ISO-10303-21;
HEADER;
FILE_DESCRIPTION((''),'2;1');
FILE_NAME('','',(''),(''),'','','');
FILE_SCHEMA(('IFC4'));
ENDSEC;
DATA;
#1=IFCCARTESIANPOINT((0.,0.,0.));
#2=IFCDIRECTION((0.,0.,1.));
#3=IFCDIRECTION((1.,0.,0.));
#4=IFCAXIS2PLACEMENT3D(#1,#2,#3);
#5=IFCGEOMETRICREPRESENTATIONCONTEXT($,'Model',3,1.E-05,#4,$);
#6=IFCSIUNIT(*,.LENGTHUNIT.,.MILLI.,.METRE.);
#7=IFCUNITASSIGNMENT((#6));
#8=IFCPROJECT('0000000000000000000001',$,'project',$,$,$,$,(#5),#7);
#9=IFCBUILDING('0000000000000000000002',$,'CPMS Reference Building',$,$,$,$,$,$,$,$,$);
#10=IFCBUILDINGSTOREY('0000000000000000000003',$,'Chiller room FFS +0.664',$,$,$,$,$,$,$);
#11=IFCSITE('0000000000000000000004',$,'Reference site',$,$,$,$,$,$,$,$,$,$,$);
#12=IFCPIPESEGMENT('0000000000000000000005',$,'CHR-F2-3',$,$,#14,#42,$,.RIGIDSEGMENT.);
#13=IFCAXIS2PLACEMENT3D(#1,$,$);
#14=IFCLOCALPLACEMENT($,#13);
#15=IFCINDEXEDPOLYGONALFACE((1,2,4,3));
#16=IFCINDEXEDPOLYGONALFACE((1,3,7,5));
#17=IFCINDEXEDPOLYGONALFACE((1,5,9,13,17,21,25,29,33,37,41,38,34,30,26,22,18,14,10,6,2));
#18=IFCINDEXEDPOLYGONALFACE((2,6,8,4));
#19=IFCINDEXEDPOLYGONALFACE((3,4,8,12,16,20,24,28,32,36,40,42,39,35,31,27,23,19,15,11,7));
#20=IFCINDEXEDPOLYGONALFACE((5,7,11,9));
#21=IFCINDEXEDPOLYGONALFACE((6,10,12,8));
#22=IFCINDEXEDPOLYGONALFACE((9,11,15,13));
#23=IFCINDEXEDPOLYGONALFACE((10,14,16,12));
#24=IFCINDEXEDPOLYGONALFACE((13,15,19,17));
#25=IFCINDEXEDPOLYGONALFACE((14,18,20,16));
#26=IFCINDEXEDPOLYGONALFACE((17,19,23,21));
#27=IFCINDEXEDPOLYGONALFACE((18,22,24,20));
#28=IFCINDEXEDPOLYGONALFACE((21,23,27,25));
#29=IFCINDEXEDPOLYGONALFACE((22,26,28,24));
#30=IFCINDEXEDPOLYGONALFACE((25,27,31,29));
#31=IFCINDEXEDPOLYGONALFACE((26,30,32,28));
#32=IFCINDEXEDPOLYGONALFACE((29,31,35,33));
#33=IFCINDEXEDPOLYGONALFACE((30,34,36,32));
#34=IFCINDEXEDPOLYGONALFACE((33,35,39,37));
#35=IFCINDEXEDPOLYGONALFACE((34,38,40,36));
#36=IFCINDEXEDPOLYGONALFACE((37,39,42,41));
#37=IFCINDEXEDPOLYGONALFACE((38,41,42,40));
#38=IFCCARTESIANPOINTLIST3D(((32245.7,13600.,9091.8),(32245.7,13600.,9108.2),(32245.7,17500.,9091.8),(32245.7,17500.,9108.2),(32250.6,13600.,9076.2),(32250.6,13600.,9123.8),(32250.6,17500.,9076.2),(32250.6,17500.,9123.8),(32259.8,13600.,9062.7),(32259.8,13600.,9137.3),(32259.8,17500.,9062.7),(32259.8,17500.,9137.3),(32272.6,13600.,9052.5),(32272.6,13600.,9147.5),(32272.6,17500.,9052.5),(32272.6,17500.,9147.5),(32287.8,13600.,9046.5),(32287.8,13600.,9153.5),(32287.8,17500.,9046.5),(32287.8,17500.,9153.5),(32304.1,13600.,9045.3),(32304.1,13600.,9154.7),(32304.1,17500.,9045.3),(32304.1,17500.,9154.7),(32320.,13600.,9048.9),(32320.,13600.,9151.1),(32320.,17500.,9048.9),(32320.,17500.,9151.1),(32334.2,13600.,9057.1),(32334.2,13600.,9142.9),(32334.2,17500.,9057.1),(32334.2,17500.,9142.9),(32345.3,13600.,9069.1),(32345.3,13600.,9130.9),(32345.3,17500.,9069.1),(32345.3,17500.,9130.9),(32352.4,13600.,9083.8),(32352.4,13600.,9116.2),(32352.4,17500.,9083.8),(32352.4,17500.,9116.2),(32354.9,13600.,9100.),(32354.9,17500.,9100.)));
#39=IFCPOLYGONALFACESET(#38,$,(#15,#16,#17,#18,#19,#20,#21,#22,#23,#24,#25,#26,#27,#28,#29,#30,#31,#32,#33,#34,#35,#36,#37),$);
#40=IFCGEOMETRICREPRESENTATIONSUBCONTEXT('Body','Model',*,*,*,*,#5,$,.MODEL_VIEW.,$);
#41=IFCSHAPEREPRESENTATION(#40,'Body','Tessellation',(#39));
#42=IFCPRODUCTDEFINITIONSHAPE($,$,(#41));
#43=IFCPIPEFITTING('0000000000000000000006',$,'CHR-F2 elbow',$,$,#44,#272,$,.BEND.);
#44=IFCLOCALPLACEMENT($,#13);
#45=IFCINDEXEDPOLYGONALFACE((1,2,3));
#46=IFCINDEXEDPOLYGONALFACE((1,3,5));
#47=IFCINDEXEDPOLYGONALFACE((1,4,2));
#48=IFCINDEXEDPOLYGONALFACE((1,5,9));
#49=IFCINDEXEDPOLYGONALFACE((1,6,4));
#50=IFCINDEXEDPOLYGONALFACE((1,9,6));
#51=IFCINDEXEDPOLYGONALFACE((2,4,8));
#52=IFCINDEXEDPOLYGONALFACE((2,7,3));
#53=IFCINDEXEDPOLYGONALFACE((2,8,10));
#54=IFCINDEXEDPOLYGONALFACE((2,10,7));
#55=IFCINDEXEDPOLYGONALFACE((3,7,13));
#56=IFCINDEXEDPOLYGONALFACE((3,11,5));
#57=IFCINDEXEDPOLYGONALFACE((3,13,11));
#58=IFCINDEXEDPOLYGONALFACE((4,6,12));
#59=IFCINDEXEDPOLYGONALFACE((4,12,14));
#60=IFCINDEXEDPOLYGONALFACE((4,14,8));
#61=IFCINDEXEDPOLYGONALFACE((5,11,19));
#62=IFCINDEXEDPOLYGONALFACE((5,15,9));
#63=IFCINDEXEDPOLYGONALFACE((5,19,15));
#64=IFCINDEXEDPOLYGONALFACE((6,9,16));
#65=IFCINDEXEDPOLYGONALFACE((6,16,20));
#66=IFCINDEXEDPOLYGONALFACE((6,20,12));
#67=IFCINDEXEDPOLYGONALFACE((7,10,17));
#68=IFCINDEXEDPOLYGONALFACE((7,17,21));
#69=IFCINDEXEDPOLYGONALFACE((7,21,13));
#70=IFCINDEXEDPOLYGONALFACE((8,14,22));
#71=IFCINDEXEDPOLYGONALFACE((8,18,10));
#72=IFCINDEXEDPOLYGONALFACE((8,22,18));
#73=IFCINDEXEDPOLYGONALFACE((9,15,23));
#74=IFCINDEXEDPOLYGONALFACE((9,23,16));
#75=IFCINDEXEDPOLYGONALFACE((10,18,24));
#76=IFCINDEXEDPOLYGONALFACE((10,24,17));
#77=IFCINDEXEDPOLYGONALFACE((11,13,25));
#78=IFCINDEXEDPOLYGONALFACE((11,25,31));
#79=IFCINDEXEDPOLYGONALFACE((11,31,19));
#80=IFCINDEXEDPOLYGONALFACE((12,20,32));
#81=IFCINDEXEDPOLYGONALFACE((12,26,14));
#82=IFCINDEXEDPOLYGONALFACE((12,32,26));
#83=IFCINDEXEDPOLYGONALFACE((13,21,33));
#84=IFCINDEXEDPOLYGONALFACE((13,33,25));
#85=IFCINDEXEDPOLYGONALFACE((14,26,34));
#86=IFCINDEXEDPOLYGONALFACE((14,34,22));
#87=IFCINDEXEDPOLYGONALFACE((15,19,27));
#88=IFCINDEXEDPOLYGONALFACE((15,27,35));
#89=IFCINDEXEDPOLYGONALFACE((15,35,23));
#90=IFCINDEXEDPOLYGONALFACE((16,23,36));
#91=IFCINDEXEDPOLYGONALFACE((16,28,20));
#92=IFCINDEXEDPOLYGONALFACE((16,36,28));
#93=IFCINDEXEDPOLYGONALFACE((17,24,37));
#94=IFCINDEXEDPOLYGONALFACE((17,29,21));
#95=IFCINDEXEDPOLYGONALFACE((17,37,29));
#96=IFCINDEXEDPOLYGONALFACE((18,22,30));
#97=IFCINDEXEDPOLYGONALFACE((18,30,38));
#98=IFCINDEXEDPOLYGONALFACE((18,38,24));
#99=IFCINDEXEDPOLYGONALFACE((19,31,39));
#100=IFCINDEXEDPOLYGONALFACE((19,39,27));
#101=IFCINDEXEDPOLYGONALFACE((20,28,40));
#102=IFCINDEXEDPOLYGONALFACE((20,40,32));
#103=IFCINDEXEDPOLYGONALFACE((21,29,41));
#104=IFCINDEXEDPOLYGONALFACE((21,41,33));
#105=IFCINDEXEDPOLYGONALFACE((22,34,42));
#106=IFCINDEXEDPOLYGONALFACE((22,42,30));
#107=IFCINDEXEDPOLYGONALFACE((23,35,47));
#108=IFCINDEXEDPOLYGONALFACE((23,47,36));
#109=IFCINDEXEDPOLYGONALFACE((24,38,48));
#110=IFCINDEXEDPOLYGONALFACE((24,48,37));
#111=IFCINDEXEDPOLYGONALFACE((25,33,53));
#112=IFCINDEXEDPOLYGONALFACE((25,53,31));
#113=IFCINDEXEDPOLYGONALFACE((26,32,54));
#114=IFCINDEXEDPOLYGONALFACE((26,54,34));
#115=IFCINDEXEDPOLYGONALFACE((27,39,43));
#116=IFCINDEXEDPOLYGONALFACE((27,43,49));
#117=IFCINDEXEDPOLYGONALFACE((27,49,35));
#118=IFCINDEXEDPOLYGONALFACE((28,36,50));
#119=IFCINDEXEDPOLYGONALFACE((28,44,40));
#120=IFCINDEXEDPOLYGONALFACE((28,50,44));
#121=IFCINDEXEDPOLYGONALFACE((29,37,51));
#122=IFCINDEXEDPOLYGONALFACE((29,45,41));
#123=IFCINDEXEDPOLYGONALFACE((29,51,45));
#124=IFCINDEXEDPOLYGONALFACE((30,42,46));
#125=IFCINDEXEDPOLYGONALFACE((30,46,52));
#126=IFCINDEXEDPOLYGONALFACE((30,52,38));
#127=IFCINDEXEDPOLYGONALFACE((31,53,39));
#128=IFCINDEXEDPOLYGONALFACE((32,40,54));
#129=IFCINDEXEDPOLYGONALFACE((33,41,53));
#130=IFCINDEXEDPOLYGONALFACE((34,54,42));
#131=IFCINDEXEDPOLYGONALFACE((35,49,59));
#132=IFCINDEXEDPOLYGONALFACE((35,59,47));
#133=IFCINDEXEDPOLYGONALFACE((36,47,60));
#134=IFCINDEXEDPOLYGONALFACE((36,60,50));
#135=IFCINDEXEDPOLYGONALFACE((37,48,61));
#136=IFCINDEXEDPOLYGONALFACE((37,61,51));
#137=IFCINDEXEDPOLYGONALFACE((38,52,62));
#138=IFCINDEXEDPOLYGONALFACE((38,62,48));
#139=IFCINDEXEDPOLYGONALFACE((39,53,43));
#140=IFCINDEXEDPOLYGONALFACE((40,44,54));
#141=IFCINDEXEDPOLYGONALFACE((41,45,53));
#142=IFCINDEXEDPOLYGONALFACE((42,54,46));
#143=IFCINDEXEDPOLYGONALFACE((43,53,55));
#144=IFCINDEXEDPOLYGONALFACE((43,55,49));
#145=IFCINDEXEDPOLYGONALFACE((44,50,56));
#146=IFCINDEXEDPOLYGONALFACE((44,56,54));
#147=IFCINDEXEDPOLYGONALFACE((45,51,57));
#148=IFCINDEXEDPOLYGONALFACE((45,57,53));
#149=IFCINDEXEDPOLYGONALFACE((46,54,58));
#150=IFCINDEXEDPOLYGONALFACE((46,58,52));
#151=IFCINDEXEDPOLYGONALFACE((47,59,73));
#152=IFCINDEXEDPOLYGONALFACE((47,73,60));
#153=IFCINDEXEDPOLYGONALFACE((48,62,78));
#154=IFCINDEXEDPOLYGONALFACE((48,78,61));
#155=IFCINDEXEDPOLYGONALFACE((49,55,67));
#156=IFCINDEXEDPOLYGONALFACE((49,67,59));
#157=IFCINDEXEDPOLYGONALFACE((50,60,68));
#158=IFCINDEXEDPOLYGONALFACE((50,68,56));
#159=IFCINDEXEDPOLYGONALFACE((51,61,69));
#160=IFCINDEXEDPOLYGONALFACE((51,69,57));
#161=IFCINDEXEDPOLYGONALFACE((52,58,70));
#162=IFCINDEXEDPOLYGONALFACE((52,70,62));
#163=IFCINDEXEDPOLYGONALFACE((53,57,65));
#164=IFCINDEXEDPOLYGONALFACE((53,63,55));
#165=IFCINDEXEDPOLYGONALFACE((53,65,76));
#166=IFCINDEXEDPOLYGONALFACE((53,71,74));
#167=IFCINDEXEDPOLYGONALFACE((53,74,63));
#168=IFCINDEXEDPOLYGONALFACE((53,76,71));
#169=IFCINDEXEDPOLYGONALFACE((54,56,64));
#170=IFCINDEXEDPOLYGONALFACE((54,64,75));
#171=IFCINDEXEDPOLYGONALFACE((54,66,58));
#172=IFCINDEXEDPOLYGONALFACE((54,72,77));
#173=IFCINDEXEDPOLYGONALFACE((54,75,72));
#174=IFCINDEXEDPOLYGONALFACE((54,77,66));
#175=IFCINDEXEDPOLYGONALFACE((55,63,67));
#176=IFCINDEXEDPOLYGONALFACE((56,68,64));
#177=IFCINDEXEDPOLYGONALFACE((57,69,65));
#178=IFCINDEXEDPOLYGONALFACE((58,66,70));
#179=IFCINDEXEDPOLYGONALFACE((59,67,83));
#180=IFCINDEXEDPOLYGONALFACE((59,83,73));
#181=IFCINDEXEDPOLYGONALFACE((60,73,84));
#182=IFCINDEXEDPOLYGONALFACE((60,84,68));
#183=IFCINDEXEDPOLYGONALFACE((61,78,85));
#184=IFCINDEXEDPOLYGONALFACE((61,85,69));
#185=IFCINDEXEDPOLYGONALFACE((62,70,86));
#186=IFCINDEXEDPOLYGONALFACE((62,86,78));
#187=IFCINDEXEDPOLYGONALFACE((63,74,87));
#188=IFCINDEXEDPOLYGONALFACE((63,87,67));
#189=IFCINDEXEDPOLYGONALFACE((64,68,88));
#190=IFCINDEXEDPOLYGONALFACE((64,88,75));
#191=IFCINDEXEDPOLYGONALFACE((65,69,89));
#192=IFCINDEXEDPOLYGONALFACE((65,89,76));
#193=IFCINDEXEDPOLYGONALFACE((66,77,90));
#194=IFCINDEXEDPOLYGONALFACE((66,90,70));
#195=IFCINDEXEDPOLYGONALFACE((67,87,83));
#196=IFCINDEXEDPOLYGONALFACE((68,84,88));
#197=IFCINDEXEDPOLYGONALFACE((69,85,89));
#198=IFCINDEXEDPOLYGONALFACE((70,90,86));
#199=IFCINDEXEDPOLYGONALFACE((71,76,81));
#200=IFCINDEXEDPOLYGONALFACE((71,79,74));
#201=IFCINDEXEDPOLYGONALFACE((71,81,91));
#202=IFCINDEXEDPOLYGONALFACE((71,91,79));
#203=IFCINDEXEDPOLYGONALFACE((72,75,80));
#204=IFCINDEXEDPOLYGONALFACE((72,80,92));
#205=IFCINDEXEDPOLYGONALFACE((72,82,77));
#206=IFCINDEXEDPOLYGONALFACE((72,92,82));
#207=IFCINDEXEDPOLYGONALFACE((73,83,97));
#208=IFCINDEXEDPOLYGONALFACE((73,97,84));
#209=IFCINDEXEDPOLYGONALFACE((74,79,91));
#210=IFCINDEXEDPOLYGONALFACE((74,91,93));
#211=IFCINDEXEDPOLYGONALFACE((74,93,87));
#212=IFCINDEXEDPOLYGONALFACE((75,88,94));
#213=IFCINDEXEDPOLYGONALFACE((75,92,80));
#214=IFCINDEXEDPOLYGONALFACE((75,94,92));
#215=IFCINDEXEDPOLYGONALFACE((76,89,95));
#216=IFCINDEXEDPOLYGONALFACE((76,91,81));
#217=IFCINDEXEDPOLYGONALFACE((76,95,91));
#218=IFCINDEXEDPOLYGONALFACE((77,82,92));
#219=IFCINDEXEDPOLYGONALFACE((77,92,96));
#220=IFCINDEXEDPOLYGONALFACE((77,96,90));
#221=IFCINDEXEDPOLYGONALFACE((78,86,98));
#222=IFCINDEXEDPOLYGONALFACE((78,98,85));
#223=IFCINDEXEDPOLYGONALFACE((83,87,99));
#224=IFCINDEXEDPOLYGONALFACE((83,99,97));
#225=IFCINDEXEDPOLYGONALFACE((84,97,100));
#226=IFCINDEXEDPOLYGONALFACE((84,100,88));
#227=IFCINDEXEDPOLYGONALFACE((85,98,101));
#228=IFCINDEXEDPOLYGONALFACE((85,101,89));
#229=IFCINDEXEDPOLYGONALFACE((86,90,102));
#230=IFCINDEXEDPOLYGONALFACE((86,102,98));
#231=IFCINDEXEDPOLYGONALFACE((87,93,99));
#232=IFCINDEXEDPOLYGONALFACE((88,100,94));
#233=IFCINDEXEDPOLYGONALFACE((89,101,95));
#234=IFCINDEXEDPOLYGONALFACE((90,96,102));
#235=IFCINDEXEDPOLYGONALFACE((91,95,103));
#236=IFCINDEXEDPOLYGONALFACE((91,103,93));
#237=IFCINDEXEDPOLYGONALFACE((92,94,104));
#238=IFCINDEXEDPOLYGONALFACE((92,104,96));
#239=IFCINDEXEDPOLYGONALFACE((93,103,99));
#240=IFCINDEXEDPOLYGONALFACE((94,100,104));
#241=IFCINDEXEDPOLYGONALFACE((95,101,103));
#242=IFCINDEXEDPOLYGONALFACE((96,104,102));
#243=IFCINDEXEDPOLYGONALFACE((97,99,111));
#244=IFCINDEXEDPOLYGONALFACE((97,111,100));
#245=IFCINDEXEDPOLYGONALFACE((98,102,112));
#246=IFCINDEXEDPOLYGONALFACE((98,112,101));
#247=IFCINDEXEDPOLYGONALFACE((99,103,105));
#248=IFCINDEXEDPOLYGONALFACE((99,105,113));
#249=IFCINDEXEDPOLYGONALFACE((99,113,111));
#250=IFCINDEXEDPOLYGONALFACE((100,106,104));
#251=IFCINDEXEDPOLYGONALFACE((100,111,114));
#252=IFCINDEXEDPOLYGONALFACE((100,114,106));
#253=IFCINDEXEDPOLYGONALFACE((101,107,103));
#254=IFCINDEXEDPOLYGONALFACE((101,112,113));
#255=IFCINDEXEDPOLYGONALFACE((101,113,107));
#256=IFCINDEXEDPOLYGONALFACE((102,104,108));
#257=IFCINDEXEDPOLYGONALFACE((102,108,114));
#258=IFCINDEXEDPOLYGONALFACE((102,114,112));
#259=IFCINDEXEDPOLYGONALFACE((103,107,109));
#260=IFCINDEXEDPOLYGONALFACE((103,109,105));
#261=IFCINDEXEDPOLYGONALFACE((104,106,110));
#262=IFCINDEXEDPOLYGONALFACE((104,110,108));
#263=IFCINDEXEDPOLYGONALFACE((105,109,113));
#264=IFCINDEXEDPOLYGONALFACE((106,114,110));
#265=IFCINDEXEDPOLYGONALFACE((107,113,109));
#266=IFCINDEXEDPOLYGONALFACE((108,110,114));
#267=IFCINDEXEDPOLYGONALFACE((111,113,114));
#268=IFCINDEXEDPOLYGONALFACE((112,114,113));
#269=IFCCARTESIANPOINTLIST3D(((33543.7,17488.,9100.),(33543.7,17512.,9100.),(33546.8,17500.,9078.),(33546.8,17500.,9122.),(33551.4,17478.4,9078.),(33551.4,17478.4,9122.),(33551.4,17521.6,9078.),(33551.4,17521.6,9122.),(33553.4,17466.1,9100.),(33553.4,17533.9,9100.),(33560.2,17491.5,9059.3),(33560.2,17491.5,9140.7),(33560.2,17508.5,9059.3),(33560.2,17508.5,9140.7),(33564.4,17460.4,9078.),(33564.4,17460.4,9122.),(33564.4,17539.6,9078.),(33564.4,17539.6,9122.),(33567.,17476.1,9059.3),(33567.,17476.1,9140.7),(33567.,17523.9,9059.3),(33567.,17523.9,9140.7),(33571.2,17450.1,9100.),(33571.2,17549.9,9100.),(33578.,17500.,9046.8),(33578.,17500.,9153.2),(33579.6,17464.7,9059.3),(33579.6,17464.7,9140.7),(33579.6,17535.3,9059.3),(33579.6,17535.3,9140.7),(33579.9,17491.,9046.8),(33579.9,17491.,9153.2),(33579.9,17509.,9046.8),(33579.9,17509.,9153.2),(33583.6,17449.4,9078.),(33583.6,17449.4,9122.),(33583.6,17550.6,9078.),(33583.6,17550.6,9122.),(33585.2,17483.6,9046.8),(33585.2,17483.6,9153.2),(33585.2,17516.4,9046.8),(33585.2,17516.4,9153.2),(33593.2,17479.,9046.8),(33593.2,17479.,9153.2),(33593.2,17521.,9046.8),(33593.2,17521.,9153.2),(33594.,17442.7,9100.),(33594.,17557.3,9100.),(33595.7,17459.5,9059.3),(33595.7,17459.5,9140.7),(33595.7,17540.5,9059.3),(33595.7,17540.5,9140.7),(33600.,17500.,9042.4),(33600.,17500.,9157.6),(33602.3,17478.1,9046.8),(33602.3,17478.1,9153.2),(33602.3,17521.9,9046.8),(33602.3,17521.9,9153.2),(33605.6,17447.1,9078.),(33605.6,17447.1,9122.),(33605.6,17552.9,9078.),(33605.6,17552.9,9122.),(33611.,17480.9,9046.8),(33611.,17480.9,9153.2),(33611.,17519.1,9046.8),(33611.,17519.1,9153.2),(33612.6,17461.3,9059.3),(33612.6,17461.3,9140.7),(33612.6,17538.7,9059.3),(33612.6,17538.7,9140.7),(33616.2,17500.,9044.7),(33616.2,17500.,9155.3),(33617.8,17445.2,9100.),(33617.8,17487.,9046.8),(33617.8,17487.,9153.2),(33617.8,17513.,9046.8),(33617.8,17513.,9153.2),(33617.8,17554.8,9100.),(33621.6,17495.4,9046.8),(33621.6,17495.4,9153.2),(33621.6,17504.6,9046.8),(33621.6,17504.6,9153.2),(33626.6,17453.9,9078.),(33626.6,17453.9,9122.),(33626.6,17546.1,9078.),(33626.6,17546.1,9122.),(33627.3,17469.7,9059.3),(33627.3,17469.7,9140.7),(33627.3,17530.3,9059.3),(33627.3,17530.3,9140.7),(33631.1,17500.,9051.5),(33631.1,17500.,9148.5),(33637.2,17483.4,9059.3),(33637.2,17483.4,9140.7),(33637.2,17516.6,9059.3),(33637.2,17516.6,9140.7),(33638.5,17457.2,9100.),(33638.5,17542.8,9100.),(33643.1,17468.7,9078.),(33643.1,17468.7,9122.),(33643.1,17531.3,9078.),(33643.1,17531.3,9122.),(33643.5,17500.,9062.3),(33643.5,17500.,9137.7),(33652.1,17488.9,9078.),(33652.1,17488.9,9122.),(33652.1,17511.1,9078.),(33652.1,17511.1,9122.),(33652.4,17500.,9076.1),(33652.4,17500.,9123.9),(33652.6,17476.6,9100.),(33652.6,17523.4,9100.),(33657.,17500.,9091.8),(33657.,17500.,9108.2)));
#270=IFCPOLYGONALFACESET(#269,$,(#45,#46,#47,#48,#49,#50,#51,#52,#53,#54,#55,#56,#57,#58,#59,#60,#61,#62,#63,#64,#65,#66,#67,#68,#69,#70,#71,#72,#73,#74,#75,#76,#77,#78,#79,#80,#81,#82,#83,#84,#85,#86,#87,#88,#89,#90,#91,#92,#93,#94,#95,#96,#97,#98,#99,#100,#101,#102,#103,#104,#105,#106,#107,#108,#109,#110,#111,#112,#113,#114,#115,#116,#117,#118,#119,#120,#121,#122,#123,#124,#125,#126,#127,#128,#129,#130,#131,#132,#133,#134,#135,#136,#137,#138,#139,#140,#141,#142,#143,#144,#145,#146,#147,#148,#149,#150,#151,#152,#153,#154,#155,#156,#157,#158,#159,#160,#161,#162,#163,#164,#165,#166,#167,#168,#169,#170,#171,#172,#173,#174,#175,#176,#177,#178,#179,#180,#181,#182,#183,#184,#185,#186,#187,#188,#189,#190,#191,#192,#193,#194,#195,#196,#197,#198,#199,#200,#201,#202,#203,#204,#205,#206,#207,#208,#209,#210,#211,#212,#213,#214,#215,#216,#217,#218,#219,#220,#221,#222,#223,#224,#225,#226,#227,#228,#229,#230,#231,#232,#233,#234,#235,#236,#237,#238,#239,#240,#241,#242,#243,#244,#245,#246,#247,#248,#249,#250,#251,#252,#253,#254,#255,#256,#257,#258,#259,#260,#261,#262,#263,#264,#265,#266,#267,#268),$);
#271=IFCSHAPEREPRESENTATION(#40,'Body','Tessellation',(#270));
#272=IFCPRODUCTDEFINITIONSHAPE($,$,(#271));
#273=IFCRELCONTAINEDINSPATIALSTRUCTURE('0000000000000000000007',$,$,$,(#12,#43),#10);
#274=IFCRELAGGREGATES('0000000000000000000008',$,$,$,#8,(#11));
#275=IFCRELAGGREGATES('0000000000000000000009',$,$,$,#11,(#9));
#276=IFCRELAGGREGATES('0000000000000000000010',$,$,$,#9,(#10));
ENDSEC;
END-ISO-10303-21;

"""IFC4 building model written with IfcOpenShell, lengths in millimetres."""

from ifc_helpers import new_model, entity, si_unit, frame, origin_with_axes, origin_2d, place, context, subcontext, project, spatial, circle_curve, outline, extrude, element, save


model = new_model("IFC4")

# Units and contexts
model_context = context("Model", 3, precision=1e-05, world=origin_with_axes())
body_context = subcontext(model_context, "Body", "Model", "MODEL_VIEW")
ifc_project = project(units=[si_unit("LENGTHUNIT", "METRE", prefix="MILLI")], contexts=[model_context])

# Site, building, storey
site = spatial("IfcSite", under=ifc_project, Name="Reference site")
building = spatial("IfcBuilding", under=site, Name="CPMS Reference Building")
storey = spatial("IfcBuildingStorey", under=building, Name="Chiller room FFS +0.664")

# Pipe segment
pipe_segment_1_placement = place(None, origin_with_axes())
element("IfcPipeSegment", 1, at=pipe_segment_1_placement, inside=storey, Name="CHR-F2-3", PredefinedType="RIGIDSEGMENT", context=body_context, shape_type="SweptSolid", body=[
    extrude(outline(circle_curve(origin_2d(), 54.9)), frame((32300.0, 17500.0, 9100.0), z_axis=(0.0, -1.0, 0.0), x_axis=(1.0, 0.0, 0.0)), (0.0, 0.0, 1.0), 3900.0),
])

# Pipe fitting
pipe_fitting_1_placement = place(None, origin_with_axes())
element("IfcPipeFitting", 2, at=pipe_fitting_1_placement, inside=storey, Name="CHR-F2 elbow", PredefinedType="BEND", context=body_context, shape_type="CSG", body=[
    entity("IfcSphere", entity("IfcAxis2Placement3D", entity("IfcCartesianPoint", [33600.0, 17500.0, 9100.0]), entity("IfcDirection", [0.0, 0.0, 1.0]), entity("IfcDirection", [1.0, 0.0, 0.0])), 57.6),
])

save(model, "model.ifc")
